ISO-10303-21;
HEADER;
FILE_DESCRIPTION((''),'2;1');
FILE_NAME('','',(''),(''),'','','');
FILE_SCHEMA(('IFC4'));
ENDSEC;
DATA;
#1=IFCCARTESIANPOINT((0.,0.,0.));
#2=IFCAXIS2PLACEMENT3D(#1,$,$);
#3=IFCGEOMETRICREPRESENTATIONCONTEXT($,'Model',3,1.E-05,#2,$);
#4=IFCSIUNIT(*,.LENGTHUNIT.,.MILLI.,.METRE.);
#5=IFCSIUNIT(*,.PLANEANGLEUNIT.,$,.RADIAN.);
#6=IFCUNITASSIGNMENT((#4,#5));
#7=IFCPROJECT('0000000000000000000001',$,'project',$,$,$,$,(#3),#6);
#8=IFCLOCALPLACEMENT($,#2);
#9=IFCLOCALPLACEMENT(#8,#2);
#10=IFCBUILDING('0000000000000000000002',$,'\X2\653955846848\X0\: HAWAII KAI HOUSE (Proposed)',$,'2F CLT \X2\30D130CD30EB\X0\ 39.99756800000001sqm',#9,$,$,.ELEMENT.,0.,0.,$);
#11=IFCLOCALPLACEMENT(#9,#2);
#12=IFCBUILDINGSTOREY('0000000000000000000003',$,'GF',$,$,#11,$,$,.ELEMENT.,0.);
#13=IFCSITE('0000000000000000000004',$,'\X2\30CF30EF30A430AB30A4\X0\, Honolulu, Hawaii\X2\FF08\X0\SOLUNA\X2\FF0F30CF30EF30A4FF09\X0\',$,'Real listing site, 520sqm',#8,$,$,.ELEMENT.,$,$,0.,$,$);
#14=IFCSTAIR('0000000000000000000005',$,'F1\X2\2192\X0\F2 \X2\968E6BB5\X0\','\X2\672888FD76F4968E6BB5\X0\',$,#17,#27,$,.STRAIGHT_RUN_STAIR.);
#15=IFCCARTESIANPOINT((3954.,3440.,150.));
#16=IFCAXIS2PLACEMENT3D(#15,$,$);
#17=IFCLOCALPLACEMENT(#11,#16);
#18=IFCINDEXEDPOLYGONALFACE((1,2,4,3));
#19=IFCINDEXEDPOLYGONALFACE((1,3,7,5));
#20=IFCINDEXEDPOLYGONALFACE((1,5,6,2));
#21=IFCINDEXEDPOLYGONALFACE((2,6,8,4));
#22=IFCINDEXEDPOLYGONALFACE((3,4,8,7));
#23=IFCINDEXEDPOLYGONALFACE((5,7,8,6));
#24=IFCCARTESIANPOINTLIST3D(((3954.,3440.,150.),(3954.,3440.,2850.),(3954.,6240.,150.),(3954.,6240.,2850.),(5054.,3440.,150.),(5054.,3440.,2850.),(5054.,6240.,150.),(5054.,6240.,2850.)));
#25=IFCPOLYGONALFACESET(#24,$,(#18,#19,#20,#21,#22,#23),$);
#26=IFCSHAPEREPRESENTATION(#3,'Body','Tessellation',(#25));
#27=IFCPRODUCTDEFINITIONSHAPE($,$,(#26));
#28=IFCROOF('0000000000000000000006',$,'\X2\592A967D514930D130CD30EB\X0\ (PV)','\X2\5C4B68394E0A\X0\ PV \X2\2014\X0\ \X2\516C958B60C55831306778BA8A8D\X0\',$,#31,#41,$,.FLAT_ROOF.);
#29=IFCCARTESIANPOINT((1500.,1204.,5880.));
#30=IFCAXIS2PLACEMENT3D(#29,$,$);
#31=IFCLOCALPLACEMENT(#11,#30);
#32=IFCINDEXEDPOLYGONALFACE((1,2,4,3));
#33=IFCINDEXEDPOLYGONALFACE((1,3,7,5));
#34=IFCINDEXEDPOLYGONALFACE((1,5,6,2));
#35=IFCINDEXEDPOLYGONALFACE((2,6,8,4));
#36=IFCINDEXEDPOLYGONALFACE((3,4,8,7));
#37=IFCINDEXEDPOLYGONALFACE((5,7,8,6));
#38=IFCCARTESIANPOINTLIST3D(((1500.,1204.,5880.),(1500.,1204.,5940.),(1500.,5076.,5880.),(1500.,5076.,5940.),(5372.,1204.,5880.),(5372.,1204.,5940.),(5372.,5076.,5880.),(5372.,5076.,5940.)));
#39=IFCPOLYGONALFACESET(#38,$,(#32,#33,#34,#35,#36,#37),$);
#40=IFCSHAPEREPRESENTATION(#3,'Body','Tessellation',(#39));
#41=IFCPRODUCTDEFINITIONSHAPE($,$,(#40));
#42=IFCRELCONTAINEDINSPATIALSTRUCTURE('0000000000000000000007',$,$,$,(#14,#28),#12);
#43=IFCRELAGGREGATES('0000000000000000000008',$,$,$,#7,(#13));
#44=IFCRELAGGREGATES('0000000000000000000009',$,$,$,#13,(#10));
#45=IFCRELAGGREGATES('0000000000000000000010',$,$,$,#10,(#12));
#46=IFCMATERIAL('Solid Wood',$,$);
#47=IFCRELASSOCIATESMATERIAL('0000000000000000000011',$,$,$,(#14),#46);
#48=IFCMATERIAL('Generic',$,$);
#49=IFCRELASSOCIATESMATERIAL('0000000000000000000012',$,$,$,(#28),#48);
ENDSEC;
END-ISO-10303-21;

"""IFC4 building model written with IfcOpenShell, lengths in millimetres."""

from ifc_helpers import new_model, si_unit, frame, frame_2d, origin, place, context, project, spatial, rectangle, extrude, material, element, save


model = new_model("IFC4")

# Units and contexts
model_context = context("Model", 3, precision=1e-05, world=origin())
ifc_project = project(units=[si_unit("LENGTHUNIT", "METRE", prefix="MILLI"), si_unit("PLANEANGLEUNIT", "RADIAN")], contexts=[model_context])

# Site, building, storey
site_placement = place(None, origin())
site = spatial("IfcSite", under=ifc_project, at=site_placement, Name="ハワイカイ, Honolulu, Hawaii（SOLUNA／ハワイ）", ObjectType="Real listing site, 520sqm", CompositionType="ELEMENT", RefElevation=0.0)
building_placement = place(site_placement, origin())
building = spatial("IfcBuilding", under=site, at=building_placement, Name="改善案: HAWAII KAI HOUSE (Proposed)", ObjectType="2F CLT パネル 39.99756800000001sqm", CompositionType="ELEMENT", ElevationOfRefHeight=0.0, ElevationOfTerrain=0.0)
storey_placement = place(building_placement, origin())
storey = spatial("IfcBuildingStorey", under=building, at=storey_placement, Name="GF", CompositionType="ELEMENT", Elevation=0.0)

# Shared definitions
ifc_material_1 = material(Name="Generic")

# Stair
ifc_material_2 = material(Name="Solid Wood")
stair_placement = place(storey_placement, frame((3954.0, 3440.0, 150.0)))
element("IfcStair", 1, at=stair_placement, inside=storey, material=ifc_material_2, Name="F1→F2 階段", Description="木製直階段", PredefinedType="STRAIGHT_RUN_STAIR", context=model_context, shape_type="SweptSolid", body=[
    extrude(rectangle(XDim=1100.0, YDim=2800.0, at=frame_2d((550.0, 1400.0))), frame((3954.0, 3440.0, 150.0)), (0.0, 0.0, 1.0), 2700.0),
])

# Roof
roof_placement = place(storey_placement, frame((1500.0, 1204.0, 5880.0)))
element("IfcRoof", 2, at=roof_placement, inside=storey, material=ifc_material_1, Name="太陽光パネル (PV)", Description="屋根上 PV — 公開情報で確認", PredefinedType="FLAT_ROOF", context=model_context, shape_type="SweptSolid", body=[
    extrude(rectangle(XDim=3872.0, YDim=3872.0, at=frame_2d((1936.0, 1936.0))), frame((1500.0, 1204.0, 5880.0)), (0.0, 0.0, 1.0), 60.0),
])

save(model, "model.ifc")
